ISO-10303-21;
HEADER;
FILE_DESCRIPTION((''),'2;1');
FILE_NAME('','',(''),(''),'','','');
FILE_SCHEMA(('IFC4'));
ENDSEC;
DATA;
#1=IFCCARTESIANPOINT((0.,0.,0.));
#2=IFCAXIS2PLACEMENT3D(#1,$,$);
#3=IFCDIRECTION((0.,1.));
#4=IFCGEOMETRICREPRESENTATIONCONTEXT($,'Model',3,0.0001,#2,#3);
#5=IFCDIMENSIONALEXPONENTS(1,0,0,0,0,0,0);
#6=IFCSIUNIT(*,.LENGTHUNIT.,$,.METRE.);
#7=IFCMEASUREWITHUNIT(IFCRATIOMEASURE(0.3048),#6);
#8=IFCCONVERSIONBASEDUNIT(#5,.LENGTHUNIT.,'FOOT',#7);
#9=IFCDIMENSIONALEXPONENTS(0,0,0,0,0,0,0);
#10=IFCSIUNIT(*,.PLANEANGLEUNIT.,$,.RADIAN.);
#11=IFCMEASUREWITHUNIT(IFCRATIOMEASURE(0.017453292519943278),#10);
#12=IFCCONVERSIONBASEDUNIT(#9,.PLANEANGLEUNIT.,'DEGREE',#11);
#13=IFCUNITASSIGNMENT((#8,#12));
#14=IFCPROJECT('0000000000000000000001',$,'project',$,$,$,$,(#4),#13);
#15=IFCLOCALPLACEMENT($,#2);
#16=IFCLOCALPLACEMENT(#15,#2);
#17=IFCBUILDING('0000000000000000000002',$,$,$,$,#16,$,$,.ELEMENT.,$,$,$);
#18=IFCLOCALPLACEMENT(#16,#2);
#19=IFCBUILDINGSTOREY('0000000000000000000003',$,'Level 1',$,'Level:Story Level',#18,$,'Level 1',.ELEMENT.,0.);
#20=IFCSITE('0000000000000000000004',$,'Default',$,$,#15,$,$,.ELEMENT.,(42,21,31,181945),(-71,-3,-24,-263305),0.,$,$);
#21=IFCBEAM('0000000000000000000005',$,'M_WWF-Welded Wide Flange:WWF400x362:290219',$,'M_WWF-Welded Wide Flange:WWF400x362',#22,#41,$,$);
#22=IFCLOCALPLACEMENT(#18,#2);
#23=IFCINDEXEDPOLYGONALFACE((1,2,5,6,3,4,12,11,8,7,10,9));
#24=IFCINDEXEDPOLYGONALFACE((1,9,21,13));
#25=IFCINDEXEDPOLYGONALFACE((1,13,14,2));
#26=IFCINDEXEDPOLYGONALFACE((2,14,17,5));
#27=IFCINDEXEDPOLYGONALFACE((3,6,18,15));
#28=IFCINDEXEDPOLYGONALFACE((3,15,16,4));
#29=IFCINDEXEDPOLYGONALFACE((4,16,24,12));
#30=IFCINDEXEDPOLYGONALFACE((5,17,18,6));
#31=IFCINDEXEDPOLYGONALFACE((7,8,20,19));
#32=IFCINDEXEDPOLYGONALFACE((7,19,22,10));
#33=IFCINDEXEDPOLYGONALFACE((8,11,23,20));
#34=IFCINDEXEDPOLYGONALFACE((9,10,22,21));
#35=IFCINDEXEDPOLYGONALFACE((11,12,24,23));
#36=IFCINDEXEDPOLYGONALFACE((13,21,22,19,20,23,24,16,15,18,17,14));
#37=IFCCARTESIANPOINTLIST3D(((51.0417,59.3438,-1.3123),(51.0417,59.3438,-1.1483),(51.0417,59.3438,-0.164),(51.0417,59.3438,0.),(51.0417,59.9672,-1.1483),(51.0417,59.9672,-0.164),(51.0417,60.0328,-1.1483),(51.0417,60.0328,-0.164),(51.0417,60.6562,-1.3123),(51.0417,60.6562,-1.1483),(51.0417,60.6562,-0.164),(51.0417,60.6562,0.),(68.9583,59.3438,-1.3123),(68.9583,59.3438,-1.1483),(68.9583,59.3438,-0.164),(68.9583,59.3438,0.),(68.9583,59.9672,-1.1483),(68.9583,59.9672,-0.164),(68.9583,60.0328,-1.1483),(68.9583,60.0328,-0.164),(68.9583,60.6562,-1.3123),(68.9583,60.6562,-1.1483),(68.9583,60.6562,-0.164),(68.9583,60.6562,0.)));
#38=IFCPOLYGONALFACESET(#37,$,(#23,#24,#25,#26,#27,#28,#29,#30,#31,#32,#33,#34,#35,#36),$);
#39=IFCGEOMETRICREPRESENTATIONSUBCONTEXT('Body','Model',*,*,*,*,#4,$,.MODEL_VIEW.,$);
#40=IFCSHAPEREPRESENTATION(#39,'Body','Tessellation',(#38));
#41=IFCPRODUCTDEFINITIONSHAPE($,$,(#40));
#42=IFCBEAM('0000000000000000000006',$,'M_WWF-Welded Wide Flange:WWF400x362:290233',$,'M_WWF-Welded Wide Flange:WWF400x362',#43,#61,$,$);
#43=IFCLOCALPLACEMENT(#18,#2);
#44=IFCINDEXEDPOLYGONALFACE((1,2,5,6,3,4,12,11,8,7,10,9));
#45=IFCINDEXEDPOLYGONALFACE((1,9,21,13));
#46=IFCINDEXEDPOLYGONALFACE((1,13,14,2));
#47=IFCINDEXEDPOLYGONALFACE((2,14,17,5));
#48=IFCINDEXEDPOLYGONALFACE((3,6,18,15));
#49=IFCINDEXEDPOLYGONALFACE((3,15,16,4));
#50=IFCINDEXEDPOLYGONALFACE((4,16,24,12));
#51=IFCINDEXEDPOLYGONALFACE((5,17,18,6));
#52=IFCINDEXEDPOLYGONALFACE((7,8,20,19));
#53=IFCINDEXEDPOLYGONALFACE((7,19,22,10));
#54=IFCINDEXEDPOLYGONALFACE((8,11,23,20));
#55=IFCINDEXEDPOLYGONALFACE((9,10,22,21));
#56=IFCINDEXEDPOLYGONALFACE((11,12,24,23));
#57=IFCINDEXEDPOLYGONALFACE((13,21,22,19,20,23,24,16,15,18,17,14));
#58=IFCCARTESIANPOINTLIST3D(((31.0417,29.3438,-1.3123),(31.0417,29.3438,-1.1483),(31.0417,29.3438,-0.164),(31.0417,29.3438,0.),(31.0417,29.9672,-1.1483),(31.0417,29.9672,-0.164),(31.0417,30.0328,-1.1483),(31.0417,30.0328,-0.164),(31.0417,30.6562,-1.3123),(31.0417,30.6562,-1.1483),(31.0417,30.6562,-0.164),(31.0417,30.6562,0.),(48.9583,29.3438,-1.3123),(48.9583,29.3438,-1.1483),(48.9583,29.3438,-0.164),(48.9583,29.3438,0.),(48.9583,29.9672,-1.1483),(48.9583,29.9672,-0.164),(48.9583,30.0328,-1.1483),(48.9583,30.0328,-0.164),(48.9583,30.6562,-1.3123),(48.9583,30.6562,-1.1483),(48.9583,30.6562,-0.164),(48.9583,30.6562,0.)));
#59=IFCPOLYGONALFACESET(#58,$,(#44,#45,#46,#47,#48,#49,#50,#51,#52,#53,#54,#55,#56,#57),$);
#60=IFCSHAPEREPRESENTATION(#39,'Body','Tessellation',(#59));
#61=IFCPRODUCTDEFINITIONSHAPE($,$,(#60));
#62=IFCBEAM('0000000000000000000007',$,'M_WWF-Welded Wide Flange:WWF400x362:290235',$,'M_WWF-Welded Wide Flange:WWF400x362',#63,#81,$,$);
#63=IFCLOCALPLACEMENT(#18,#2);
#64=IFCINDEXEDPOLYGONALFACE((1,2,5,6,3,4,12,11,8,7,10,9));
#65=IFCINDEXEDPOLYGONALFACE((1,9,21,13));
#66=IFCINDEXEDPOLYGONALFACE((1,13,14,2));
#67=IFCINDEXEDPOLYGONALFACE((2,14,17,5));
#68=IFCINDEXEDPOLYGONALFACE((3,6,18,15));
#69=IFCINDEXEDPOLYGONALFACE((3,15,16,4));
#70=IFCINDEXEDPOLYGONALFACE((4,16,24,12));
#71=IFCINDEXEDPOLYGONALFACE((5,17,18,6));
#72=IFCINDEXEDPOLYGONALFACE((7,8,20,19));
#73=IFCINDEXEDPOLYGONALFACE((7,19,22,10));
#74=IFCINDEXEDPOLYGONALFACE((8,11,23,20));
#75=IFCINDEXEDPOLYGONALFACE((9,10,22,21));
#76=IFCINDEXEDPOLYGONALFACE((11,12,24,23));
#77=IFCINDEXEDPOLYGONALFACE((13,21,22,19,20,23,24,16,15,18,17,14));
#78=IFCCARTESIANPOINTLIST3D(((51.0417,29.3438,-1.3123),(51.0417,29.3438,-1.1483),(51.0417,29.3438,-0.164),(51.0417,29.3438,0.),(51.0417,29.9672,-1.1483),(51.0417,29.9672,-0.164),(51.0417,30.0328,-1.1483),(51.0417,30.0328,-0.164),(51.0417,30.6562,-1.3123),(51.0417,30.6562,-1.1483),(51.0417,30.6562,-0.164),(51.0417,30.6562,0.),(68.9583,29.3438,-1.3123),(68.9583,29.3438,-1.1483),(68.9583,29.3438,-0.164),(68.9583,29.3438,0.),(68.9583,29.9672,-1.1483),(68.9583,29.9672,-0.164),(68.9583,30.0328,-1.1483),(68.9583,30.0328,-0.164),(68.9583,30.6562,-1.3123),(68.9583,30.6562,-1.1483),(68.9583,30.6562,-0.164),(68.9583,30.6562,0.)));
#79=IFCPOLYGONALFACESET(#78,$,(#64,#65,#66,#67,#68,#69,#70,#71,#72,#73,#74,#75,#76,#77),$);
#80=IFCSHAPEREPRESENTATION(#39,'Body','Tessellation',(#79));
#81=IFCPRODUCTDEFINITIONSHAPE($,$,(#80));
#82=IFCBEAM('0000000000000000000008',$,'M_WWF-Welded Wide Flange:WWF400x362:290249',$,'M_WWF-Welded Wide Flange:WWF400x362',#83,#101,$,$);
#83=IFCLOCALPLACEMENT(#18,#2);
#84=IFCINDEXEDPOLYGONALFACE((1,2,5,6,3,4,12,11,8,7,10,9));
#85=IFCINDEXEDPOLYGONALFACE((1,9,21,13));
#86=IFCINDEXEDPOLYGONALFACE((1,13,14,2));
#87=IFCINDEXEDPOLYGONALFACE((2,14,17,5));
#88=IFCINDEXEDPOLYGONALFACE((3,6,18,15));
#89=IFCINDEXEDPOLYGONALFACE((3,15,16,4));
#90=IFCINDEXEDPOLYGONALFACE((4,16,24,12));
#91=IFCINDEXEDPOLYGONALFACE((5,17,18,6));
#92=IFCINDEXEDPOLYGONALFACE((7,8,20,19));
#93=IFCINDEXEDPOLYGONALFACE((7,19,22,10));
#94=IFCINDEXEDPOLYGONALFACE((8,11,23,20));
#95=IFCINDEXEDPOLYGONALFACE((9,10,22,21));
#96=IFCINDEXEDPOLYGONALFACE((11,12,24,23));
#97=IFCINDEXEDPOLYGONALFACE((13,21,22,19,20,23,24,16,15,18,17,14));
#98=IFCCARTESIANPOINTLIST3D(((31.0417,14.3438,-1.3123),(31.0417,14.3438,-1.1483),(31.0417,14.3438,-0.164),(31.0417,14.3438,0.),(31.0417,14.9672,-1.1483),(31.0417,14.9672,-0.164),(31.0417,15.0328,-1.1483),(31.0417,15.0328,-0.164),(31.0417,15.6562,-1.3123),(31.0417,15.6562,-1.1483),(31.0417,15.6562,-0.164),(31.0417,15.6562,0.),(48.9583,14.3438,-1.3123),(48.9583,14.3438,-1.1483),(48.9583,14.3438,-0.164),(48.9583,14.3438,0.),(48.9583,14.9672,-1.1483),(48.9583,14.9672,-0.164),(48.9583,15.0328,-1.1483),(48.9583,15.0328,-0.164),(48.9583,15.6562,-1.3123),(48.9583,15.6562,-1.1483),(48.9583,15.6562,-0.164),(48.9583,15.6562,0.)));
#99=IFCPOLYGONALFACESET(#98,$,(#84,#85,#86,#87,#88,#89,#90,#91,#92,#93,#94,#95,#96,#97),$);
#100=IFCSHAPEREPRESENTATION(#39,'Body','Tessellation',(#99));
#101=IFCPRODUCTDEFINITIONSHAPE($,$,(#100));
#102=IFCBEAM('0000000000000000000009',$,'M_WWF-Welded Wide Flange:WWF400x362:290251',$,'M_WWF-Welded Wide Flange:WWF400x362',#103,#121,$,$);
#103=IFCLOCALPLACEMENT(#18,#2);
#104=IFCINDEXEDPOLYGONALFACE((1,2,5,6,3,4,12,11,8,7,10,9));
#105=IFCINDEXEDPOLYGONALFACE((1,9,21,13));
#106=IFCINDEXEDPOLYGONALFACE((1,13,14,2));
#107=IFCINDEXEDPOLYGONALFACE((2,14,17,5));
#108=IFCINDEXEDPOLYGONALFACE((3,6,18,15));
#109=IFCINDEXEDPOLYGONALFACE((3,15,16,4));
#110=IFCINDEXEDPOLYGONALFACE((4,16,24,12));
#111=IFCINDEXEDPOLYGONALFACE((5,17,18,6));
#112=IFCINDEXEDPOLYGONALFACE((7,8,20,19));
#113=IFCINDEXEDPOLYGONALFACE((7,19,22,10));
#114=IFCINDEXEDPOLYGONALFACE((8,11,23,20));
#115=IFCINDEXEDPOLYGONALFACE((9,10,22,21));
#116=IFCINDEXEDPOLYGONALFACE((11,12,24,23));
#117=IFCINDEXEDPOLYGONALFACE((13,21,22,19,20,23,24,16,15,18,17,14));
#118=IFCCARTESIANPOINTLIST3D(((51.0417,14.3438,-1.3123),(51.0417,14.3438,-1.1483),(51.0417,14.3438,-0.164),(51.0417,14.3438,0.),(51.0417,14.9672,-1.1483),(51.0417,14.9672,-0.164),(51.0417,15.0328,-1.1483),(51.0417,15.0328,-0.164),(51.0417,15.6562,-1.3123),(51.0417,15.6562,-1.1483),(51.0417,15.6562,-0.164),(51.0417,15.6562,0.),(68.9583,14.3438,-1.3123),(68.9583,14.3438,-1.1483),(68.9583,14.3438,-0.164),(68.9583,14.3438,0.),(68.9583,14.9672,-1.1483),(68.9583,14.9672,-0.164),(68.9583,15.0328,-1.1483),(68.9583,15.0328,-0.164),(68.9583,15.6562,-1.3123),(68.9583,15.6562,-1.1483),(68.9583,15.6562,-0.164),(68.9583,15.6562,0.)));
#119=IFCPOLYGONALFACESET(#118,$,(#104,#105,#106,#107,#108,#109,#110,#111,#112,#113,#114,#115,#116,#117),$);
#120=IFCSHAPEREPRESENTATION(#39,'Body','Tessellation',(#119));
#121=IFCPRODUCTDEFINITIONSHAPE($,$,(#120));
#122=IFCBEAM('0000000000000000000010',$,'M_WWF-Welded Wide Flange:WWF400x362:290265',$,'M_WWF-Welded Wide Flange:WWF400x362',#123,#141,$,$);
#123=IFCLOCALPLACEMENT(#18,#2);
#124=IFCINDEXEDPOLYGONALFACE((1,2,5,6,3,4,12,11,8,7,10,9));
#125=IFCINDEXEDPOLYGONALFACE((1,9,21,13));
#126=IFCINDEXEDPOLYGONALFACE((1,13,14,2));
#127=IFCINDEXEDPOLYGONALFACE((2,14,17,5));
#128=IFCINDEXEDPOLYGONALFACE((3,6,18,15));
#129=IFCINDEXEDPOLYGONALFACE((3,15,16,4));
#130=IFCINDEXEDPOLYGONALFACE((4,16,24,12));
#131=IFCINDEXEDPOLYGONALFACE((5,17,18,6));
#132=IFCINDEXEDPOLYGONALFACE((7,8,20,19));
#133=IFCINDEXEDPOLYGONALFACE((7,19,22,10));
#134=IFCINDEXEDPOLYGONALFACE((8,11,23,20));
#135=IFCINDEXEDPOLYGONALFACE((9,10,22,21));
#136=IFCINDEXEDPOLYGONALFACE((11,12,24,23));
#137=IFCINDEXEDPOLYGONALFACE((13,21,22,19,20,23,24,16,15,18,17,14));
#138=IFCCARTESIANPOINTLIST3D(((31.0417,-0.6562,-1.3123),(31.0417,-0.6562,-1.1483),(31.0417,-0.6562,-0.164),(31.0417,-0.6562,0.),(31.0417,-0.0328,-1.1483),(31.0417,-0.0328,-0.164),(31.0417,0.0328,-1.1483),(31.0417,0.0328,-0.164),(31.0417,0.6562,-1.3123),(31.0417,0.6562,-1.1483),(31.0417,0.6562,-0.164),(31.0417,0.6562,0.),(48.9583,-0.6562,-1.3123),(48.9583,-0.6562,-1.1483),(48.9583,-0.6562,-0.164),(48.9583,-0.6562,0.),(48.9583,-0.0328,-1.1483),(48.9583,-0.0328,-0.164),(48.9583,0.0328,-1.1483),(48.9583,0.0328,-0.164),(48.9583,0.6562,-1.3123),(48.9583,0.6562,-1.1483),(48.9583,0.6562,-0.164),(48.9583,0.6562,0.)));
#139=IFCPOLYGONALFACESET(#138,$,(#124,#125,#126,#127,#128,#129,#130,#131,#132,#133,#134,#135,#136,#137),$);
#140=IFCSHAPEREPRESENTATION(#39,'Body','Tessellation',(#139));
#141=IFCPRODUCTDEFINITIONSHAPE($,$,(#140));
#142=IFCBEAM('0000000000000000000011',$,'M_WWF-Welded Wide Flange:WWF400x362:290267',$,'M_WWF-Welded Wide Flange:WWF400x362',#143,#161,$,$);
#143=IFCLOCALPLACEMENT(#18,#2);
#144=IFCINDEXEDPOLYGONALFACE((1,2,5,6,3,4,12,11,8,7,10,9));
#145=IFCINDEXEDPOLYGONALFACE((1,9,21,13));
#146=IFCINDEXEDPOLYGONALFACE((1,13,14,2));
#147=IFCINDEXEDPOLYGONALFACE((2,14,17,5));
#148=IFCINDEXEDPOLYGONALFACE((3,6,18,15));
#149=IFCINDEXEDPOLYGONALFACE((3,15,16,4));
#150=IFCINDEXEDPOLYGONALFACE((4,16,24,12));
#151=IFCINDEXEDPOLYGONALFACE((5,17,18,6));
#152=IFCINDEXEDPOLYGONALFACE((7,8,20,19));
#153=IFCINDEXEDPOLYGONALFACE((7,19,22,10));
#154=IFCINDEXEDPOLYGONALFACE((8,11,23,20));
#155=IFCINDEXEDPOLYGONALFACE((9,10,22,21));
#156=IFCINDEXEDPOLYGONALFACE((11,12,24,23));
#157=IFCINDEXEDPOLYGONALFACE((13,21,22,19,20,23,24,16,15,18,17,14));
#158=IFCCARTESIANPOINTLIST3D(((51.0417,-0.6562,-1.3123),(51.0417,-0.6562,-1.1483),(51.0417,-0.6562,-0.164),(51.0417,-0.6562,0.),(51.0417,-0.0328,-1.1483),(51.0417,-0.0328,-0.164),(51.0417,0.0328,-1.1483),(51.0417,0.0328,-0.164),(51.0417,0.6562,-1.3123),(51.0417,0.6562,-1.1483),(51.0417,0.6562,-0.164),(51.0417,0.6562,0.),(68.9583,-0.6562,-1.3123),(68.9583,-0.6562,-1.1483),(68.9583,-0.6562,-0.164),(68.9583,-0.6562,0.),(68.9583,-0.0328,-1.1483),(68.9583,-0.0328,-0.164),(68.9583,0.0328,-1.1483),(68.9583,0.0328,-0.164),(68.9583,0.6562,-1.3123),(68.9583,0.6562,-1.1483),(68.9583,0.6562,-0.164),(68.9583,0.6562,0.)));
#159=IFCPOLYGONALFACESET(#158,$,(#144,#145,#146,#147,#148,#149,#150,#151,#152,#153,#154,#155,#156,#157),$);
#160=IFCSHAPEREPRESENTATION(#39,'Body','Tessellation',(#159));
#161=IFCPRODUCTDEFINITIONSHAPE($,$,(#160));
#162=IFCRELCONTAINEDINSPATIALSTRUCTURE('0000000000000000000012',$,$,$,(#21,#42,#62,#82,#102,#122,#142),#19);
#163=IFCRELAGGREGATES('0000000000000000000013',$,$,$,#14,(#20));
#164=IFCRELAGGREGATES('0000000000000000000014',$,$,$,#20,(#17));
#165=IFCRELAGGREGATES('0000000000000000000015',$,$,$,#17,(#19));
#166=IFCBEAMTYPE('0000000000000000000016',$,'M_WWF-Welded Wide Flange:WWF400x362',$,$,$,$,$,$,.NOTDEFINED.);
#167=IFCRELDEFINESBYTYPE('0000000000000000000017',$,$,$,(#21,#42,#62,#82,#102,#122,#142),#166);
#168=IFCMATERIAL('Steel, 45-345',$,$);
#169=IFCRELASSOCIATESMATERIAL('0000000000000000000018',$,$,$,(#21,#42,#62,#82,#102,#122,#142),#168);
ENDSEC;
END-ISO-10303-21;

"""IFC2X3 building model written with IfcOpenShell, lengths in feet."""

from ifc_helpers import new_model, entity, si_unit, converted_unit, direction, frame, frame_2d, origin, place, context, subcontext, project, spatial, i_section, extrude, material, type_object, element, save


model = new_model("IFC2X3")

# Units and contexts
model_context = context("Model", 3, precision=0.0001, world=origin(), true_north=direction((0.0, 1.0)))
body_context = subcontext(model_context, "Body", "Model", "MODEL_VIEW")
ifc_project = project(units=[converted_unit("LENGTHUNIT", "FOOT", entity("IfcRatioMeasure", 0.3048), si_unit("LENGTHUNIT", "METRE"), dimensions=[1, 0, 0, 0, 0, 0, 0]), converted_unit("PLANEANGLEUNIT", "DEGREE", entity("IfcRatioMeasure", 0.017453292519943278), si_unit("PLANEANGLEUNIT", "RADIAN"), dimensions=[0, 0, 0, 0, 0, 0, 0])], contexts=[model_context])

# Site, building, storey
site_placement = place(None, origin())
site = spatial("IfcSite", under=ifc_project, at=site_placement, Name="Default", CompositionType="ELEMENT", RefLatitude=(42, 21, 31, 181945), RefLongitude=(-71, -3, -24, -263305), RefElevation=0.0)
building_placement = place(site_placement, origin())
building = spatial("IfcBuilding", under=site, at=building_placement, CompositionType="ELEMENT")
storey_placement = place(building_placement, origin())
storey = spatial("IfcBuildingStorey", under=building, at=storey_placement, Name="Level 1", ObjectType="Level:Story Level", LongName="Level 1", CompositionType="ELEMENT", Elevation=0.0)

# Shared definitions
ifc_material = material(Name="Steel, 45-345")

# Beams
beam_type = type_object("IfcBeamType", Name="M_WWF-Welded Wide Flange:WWF400x362", PredefinedType="NOTDEFINED")
beam_1_placement = place(storey_placement, frame((50.0, 60.0, 0.0)))
element("IfcBeam", 1, at=beam_1_placement, inside=storey, type_object=beam_type, material=ifc_material, Name="M_WWF-Welded Wide Flange:WWF400x362:290219", ObjectType="M_WWF-Welded Wide Flange:WWF400x362", context=body_context, shape_type="SweptSolid", body=[
    extrude(i_section(OverallWidth=1.3123, OverallDepth=1.3123, WebThickness=0.0656, FlangeThickness=0.164, at=frame_2d((0.0, 0.0), x_axis=(0.0, 1.0))), frame((1.0417, 0.0, -0.6562), z_axis=(1.0, 0.0, 0.0), x_axis=(0.0, 0.0, -1.0)), (0.0, 0.0, 1.0), 17.9167),
])
beam_2_placement = place(storey_placement, frame((30.0, 30.0, 0.0)))
element("IfcBeam", 2, at=beam_2_placement, inside=storey, type_object=beam_type, material=ifc_material, Name="M_WWF-Welded Wide Flange:WWF400x362:290233", ObjectType="M_WWF-Welded Wide Flange:WWF400x362", context=body_context, shape_type="SweptSolid", body=[
    extrude(i_section(OverallWidth=1.3123, OverallDepth=1.3123, WebThickness=0.0656, FlangeThickness=0.164, at=frame_2d((0.0, 0.0), x_axis=(0.0, 1.0))), frame((1.0417, 0.0, -0.6562), z_axis=(1.0, 0.0, 0.0), x_axis=(0.0, 0.0, -1.0)), (0.0, 0.0, 1.0), 17.9167),
])
beam_3_placement = place(storey_placement, frame((50.0, 30.0, 0.0)))
element("IfcBeam", 3, at=beam_3_placement, inside=storey, type_object=beam_type, material=ifc_material, Name="M_WWF-Welded Wide Flange:WWF400x362:290235", ObjectType="M_WWF-Welded Wide Flange:WWF400x362", context=body_context, shape_type="SweptSolid", body=[
    extrude(i_section(OverallWidth=1.3123, OverallDepth=1.3123, WebThickness=0.0656, FlangeThickness=0.164, at=frame_2d((0.0, 0.0), x_axis=(0.0, 1.0))), frame((1.0417, 0.0, -0.6562), z_axis=(1.0, 0.0, 0.0), x_axis=(0.0, 0.0, -1.0)), (0.0, 0.0, 1.0), 17.9167),
])
beam_4_placement = place(storey_placement, frame((30.0, 15.0, 0.0)))
element("IfcBeam", 4, at=beam_4_placement, inside=storey, type_object=beam_type, material=ifc_material, Name="M_WWF-Welded Wide Flange:WWF400x362:290249", ObjectType="M_WWF-Welded Wide Flange:WWF400x362", context=body_context, shape_type="SweptSolid", body=[
    extrude(i_section(OverallWidth=1.3123, OverallDepth=1.3123, WebThickness=0.0656, FlangeThickness=0.164, at=frame_2d((0.0, 0.0), x_axis=(0.0, 1.0))), frame((1.0417, 0.0, -0.6562), z_axis=(1.0, 0.0, 0.0), x_axis=(0.0, 0.0, -1.0)), (0.0, 0.0, 1.0), 17.9167),
])
beam_5_placement = place(storey_placement, frame((50.0, 15.0, 0.0)))
element("IfcBeam", 5, at=beam_5_placement, inside=storey, type_object=beam_type, material=ifc_material, Name="M_WWF-Welded Wide Flange:WWF400x362:290251", ObjectType="M_WWF-Welded Wide Flange:WWF400x362", context=body_context, shape_type="SweptSolid", body=[
    extrude(i_section(OverallWidth=1.3123, OverallDepth=1.3123, WebThickness=0.0656, FlangeThickness=0.164, at=frame_2d((0.0, 0.0), x_axis=(0.0, 1.0))), frame((1.0417, 0.0, -0.6562), z_axis=(1.0, 0.0, 0.0), x_axis=(0.0, 0.0, -1.0)), (0.0, 0.0, 1.0), 17.9167),
])
beam_6_placement = place(storey_placement, frame((30.0, 0.0, 0.0)))
element("IfcBeam", 6, at=beam_6_placement, inside=storey, type_object=beam_type, material=ifc_material, Name="M_WWF-Welded Wide Flange:WWF400x362:290265", ObjectType="M_WWF-Welded Wide Flange:WWF400x362", context=body_context, shape_type="SweptSolid", body=[
    extrude(i_section(OverallWidth=1.3123, OverallDepth=1.3123, WebThickness=0.0656, FlangeThickness=0.164, at=frame_2d((0.0, 0.0), x_axis=(0.0, 1.0))), frame((1.0417, 0.0, -0.6562), z_axis=(1.0, 0.0, 0.0), x_axis=(0.0, 0.0, -1.0)), (0.0, 0.0, 1.0), 17.9167),
])
beam_7_placement = place(storey_placement, frame((50.0, 0.0, 0.0)))
element("IfcBeam", 7, at=beam_7_placement, inside=storey, type_object=beam_type, material=ifc_material, Name="M_WWF-Welded Wide Flange:WWF400x362:290267", ObjectType="M_WWF-Welded Wide Flange:WWF400x362", context=body_context, shape_type="SweptSolid", body=[
    extrude(i_section(OverallWidth=1.3123, OverallDepth=1.3123, WebThickness=0.0656, FlangeThickness=0.164, at=frame_2d((0.0, 0.0), x_axis=(0.0, 1.0))), frame((1.0417, 0.0, -0.6562), z_axis=(1.0, 0.0, 0.0), x_axis=(0.0, 0.0, -1.0)), (0.0, 0.0, 1.0), 17.9167),
])

save(model, "model.ifc")
